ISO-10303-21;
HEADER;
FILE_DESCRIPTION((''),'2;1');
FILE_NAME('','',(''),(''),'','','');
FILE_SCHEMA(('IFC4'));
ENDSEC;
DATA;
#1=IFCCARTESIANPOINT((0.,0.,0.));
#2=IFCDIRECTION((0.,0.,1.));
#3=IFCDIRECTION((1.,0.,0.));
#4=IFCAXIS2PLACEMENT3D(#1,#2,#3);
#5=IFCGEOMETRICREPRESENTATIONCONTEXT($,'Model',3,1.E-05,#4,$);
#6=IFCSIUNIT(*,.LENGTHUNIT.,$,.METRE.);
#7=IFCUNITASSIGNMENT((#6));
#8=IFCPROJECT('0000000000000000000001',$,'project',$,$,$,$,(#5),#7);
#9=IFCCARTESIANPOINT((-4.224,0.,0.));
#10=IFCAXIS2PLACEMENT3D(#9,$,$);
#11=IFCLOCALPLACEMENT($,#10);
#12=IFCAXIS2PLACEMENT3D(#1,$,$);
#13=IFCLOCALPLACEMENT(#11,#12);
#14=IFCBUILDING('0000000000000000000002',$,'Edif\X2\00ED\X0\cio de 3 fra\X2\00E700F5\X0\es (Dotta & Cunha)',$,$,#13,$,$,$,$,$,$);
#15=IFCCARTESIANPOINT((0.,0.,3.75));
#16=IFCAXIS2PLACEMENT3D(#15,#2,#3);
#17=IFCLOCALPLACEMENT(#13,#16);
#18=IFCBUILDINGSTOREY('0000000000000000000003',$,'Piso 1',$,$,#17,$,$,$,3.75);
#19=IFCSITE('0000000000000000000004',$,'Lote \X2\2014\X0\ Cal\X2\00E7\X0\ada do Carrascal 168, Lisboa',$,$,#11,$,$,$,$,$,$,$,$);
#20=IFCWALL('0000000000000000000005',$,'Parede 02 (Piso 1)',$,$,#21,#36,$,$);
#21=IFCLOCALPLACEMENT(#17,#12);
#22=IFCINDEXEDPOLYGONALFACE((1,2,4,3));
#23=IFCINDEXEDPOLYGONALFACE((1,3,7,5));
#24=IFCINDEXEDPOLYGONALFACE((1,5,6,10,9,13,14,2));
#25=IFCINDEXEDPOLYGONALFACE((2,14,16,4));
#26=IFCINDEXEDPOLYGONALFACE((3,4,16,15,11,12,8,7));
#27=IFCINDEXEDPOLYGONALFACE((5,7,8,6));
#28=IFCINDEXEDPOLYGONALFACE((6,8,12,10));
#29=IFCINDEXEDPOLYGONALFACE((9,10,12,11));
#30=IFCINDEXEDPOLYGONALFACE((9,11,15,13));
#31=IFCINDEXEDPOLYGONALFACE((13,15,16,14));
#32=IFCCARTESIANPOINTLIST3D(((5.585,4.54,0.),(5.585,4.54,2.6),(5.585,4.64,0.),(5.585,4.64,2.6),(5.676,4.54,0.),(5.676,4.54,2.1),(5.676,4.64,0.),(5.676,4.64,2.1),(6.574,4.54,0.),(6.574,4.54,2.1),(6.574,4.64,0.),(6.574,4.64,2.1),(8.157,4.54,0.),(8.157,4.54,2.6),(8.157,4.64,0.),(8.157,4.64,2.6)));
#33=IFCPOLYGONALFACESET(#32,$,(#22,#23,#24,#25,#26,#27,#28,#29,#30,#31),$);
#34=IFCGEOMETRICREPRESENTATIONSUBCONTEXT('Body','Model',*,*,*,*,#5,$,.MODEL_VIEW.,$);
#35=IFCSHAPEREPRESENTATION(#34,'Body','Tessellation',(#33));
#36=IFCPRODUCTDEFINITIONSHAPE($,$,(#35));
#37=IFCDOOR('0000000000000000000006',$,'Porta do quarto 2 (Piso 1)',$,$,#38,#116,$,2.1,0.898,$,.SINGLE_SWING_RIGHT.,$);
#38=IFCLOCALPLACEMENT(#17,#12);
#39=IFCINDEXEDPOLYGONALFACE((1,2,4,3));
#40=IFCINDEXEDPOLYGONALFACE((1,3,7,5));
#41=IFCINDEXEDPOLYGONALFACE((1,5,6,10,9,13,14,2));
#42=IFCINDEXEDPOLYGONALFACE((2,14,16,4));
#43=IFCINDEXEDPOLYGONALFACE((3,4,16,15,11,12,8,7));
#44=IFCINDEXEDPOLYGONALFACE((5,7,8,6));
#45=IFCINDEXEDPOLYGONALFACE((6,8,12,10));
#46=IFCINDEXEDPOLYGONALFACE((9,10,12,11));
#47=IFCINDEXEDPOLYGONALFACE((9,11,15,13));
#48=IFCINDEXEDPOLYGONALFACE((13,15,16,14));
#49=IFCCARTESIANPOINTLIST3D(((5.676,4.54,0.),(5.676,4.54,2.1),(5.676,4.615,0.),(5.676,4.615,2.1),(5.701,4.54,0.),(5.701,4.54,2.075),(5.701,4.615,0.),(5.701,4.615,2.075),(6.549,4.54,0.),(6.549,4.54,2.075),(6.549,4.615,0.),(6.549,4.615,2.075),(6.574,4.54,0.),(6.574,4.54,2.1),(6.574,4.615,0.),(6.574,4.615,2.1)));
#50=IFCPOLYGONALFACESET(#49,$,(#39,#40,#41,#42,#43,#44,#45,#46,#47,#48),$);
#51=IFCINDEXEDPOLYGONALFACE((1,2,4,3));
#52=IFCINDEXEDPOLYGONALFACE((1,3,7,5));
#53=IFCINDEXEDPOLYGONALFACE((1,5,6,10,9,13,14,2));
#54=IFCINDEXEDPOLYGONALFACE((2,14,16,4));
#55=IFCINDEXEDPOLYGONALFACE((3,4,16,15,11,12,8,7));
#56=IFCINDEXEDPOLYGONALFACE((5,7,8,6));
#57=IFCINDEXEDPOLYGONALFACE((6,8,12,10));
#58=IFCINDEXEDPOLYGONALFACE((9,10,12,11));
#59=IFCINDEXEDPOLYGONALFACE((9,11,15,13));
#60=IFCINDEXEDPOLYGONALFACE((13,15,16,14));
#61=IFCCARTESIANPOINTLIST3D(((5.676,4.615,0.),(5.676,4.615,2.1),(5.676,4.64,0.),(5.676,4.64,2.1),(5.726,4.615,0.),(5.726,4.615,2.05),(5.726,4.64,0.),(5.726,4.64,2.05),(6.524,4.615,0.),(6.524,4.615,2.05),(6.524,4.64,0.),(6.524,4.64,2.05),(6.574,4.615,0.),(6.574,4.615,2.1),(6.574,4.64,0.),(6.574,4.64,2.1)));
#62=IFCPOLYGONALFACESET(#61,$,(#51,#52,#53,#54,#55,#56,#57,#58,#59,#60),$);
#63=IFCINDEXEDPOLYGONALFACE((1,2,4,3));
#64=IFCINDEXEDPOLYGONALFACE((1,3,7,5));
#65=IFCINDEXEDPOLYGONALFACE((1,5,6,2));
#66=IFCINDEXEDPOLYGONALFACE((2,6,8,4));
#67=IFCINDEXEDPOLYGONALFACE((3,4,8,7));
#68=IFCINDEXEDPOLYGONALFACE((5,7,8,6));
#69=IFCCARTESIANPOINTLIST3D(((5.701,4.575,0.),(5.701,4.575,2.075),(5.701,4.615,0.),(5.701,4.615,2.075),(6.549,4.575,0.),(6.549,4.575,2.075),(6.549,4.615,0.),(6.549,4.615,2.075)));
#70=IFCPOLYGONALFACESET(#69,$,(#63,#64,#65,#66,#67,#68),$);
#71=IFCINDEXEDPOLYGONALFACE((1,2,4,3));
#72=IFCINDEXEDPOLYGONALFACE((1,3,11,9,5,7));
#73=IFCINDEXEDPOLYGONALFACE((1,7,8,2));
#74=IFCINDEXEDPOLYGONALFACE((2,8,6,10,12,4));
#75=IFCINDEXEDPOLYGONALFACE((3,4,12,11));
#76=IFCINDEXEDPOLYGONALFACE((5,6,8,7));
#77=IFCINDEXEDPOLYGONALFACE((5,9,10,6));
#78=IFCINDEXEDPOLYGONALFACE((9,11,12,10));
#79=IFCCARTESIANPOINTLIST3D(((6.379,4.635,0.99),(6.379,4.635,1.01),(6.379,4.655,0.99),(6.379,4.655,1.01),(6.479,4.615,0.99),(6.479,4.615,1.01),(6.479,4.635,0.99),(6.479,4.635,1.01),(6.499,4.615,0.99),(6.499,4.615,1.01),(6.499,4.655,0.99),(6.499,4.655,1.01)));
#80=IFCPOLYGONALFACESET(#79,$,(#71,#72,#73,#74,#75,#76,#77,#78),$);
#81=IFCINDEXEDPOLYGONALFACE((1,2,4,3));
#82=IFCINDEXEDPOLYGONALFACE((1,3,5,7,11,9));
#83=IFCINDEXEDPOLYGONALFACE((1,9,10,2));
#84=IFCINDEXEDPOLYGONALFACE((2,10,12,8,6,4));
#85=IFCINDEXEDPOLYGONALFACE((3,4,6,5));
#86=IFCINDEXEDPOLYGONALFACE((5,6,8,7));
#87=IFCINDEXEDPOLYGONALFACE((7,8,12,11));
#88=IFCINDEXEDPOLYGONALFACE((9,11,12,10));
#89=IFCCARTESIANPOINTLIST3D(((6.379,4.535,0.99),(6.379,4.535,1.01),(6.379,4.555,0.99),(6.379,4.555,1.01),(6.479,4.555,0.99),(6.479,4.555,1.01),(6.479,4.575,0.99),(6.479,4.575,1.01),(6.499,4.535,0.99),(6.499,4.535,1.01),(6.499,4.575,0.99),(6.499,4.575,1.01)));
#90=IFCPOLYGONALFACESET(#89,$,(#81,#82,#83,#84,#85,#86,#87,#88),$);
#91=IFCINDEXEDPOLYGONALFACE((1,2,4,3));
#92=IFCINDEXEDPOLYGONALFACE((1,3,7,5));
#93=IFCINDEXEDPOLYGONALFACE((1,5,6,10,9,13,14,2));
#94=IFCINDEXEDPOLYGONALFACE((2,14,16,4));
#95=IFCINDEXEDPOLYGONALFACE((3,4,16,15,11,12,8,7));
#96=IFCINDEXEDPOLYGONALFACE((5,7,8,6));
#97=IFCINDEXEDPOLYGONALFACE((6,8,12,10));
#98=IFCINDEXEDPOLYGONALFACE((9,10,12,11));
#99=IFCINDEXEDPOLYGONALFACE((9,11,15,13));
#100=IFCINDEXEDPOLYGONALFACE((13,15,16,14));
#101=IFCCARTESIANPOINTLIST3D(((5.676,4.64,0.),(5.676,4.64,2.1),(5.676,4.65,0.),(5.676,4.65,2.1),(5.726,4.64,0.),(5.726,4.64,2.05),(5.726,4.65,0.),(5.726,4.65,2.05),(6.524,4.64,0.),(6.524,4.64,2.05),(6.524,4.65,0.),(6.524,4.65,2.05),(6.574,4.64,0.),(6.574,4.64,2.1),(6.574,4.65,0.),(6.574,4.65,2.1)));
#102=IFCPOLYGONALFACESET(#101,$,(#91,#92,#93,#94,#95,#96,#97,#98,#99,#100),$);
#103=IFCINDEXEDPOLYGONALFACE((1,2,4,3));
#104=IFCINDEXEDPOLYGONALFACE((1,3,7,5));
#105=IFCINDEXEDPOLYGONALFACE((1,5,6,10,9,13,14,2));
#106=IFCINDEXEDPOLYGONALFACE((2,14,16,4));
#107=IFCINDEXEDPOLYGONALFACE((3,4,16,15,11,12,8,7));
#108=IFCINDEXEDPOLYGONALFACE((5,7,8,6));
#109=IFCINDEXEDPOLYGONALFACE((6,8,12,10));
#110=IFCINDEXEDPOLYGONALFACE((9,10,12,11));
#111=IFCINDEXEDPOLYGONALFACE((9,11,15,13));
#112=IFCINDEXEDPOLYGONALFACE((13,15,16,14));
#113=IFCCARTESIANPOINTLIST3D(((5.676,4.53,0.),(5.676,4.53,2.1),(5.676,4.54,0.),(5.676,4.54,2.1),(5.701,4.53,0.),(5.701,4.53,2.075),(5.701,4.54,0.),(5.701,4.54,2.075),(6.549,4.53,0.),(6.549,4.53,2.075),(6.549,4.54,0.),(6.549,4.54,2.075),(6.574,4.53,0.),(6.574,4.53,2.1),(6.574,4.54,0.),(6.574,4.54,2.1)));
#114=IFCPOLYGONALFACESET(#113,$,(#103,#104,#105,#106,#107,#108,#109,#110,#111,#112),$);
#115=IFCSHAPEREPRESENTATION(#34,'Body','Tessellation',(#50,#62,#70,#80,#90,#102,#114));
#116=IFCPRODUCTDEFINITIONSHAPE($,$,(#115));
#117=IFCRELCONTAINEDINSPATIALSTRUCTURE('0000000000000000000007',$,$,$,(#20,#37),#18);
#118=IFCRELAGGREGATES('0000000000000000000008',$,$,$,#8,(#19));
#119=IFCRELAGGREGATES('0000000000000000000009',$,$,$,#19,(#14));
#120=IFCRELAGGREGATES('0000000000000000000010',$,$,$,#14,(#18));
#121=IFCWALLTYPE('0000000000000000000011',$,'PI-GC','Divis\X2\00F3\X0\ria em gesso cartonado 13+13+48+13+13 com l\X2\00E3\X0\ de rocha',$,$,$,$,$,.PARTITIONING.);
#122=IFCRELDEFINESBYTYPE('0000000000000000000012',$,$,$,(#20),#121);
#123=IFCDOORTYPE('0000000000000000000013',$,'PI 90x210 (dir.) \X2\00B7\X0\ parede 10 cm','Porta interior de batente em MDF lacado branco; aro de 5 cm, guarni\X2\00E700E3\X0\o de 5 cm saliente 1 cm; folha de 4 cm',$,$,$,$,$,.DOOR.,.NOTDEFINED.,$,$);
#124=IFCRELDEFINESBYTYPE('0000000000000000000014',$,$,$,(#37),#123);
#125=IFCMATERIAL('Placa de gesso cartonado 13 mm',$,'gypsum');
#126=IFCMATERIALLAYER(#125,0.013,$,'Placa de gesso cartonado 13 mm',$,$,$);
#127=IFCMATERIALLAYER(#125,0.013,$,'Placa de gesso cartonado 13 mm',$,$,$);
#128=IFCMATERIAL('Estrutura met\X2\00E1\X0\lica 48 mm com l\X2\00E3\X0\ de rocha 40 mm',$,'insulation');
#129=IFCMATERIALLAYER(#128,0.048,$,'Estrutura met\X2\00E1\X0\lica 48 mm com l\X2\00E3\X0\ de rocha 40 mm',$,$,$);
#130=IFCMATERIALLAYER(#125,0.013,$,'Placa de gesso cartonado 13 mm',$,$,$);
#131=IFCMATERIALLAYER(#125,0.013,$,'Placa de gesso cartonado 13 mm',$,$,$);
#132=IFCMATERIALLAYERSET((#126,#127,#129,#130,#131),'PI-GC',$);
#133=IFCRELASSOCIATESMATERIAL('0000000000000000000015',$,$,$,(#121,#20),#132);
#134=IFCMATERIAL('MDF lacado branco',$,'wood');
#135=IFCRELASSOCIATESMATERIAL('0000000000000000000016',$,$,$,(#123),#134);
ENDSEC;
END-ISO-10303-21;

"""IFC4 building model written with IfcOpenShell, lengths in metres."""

from ifc_helpers import new_model, si_unit, frame, origin, origin_with_axes, place, context, subcontext, project, spatial, line, indexed_curve, outline, extrude, source, transform, mapped, material, layer, layer_set, layer_usage, type_object, type_shapes, element, fill, save


model = new_model("IFC4")

# Units and contexts
model_context = context("Model", 3, precision=1e-05, world=origin_with_axes())
body_context = subcontext(model_context, "Body", "Model", "MODEL_VIEW")
ifc_project = project(units=[si_unit("LENGTHUNIT", "METRE")], contexts=[model_context])

# Site, building, storey
site_placement = place(None, frame((-4.224, 0.0, 0.0)))
site = spatial("IfcSite", under=ifc_project, at=site_placement, Name="Lote — Calçada do Carrascal 168, Lisboa")
building_placement = place(site_placement, origin())
building = spatial("IfcBuilding", under=site, at=building_placement, Name="Edifício de 3 frações (Dotta & Cunha)")
storey_placement = place(building_placement, frame((0.0, 0.0, 3.75), z_axis=(0.0, 0.0, 1.0), x_axis=(1.0, 0.0, 0.0)))
storey = spatial("IfcBuildingStorey", under=building, at=storey_placement, Name="Piso 1", Elevation=3.75)

# Shared definitions
ifc_material_1 = material(Name="MDF lacado branco", Category="wood")

# Shared definitions
ifc_material_2 = material(Name="Placa de gesso cartonado 13 mm", Category="gypsum")
ifc_layer_1 = layer(ifc_material_2, 0.013, Name="Placa de gesso cartonado 13 mm")
ifc_layer_2 = layer(ifc_material_2, 0.013, Name="Placa de gesso cartonado 13 mm")
ifc_material_3 = material(Name="Estrutura metálica 48 mm com lã de rocha 40 mm", Category="insulation")
ifc_layer_3 = layer(ifc_material_3, 0.048, Name="Estrutura metálica 48 mm com lã de rocha 40 mm")
ifc_layer_4 = layer(ifc_material_2, 0.013, Name="Placa de gesso cartonado 13 mm")
ifc_layer_5 = layer(ifc_material_2, 0.013, Name="Placa de gesso cartonado 13 mm")
ifc_layer_set_1 = layer_set([ifc_layer_1, ifc_layer_2, ifc_layer_3, ifc_layer_4, ifc_layer_5], Name="PI-GC")
wall_type_1 = type_object("IfcWallType", Name="PI-GC", Description="Divisória em gesso cartonado 13+13+48+13+13 com lã de rocha", PredefinedType="PARTITIONING", material=ifc_layer_set_1)

# Wall, opening, door
ifc_layer_usage_1 = layer_usage(ifc_layer_set_1, "AXIS2", "POSITIVE", 0.0)
wall_1_placement = place(storey_placement, origin_with_axes())
wall_1 = element("IfcWall", 1, at=wall_1_placement, inside=storey, type_object=wall_type_1, material=ifc_layer_usage_1, Name="Parede 02 (Piso 1)", context=body_context, shape_type="SweptSolid", body=[
    extrude(outline(indexed_curve([(8.157, 4.54), (8.157, 4.64), (5.585, 4.64), (5.585, 4.54)], segments=[line(1, 2, 3, 4, 1)])), origin_with_axes(), (0.0, 0.0, 1.0), 2.6),
])
opening_1_placement = place(wall_1_placement, origin_with_axes())
opening_1 = element("IfcOpeningElement", 2, at=opening_1_placement, cuts=wall_1, context=body_context, shape_type="SweptSolid", body=[
    extrude(outline(indexed_curve([(6.574, 4.538), (6.574, 4.642), (5.676, 4.642), (5.676, 4.538)], segments=[line(1, 2, 3, 4, 1)])), origin_with_axes(), (0.0, 0.0, 1.0), 2.1),
])
door_type_1 = type_object("IfcDoorType", Name="PI 90x210 (dir.) · parede 10 cm", Description="Porta interior de batente em MDF lacado branco; aro de 5 cm, guarnição de 5 cm saliente 1 cm; folha de 4 cm", OperationType="NOTDEFINED", PredefinedType="DOOR", material=ifc_material_1)
shared_shape_1 = source(origin_with_axes(), body_context, "Body", "SweptSolid", [
    extrude(outline(indexed_curve([(0.0, 0.0), (0.0, 2.1), (0.898, 2.1), (0.898, 0.0), (0.873, 0.0), (0.873, 2.075), (0.025, 2.075), (0.025, 0.0)], segments=[line(1, 2, 3, 4, 5, 6, 7, 8, 1)])), frame((0.0, 0.025, 0.0), z_axis=(0.0, -1.0, 0.0), x_axis=(1.0, 0.0, 0.0)), (0.0, 0.0, -1.0), 0.075),
    extrude(outline(indexed_curve([(0.0, 0.0), (0.0, 2.1), (0.898, 2.1), (0.898, 0.0), (0.848, 0.0), (0.848, 2.05), (0.05, 2.05), (0.05, 0.0)], segments=[line(1, 2, 3, 4, 5, 6, 7, 8, 1)])), frame((0.0, 0.0, 0.0), z_axis=(0.0, -1.0, 0.0), x_axis=(1.0, 0.0, 0.0)), (0.0, 0.0, -1.0), 0.025),
    extrude(outline(indexed_curve([(0.0, 0.0), (0.848, 0.0), (0.848, 0.04), (0.0, 0.04)], segments=[line(1, 2, 3, 4, 1)])), frame((0.025, 0.025, 0.0), z_axis=(0.0, 0.0, 1.0), x_axis=(1.0, 0.0, 0.0)), (0.0, 0.0, 1.0), 2.075),
    extrude(outline(indexed_curve([(0.0, 0.0), (0.0, -0.04), (0.12, -0.04), (0.12, -0.02), (0.02, -0.02), (0.02, 0.0)], segments=[line(1, 2, 3, 4, 5, 6, 1)])), frame((0.075, 0.025, 0.99), z_axis=(0.0, 0.0, 1.0), x_axis=(1.0, 0.0, 0.0)), (0.0, 0.0, 1.0), 0.02),
    extrude(outline(indexed_curve([(0.0, 0.0), (0.0, 0.04), (0.12, 0.04), (0.12, 0.02), (0.02, 0.02), (0.02, 0.0)], segments=[line(1, 2, 3, 4, 5, 6, 1)])), frame((0.075, 0.065, 0.99), z_axis=(0.0, 0.0, 1.0), x_axis=(1.0, 0.0, 0.0)), (0.0, 0.0, 1.0), 0.02),
    extrude(outline(indexed_curve([(0.0, 0.0), (0.0, 2.1), (0.898, 2.1), (0.898, 0.0), (0.848, 0.0), (0.848, 2.05), (0.05, 2.05), (0.05, 0.0)], segments=[line(1, 2, 3, 4, 5, 6, 7, 8, 1)])), frame((0.0, -0.01, 0.0), z_axis=(0.0, -1.0, 0.0), x_axis=(1.0, 0.0, 0.0)), (0.0, 0.0, -1.0), 0.01),
    extrude(outline(indexed_curve([(0.0, 0.0), (0.0, 2.1), (0.898, 2.1), (0.898, 0.0), (0.873, 0.0), (0.873, 2.075), (0.025, 2.075), (0.025, 0.0)], segments=[line(1, 2, 3, 4, 5, 6, 7, 8, 1)])), frame((0.0, 0.1, 0.0), z_axis=(0.0, -1.0, 0.0), x_axis=(1.0, 0.0, 0.0)), (0.0, 0.0, -1.0), 0.01),
])
type_shapes(door_type_1, [shared_shape_1])
door_1_placement = place(storey_placement, frame((6.574, 4.64, 0.0), z_axis=(0.0, 0.0, 1.0), x_axis=(-1.0, 0.0, 0.0)))
door_1 = element("IfcDoor", 3, at=door_1_placement, inside=storey, type_object=door_type_1, Name="Porta do quarto 2 (Piso 1)", OperationType="SINGLE_SWING_RIGHT", OverallHeight=2.1, OverallWidth=0.898, context=body_context, shape_type="MappedRepresentation", body=[
    mapped(shared_shape_1, transform((0.0, 0.0, 0.0), x_axis=(1.0, 0.0, 0.0), y_axis=(0.0, 1.0, 0.0), z_axis=(0.0, 0.0, 1.0), scale=1.0)),
])
fill(opening_1, door_1)

save(model, "model.ifc")
